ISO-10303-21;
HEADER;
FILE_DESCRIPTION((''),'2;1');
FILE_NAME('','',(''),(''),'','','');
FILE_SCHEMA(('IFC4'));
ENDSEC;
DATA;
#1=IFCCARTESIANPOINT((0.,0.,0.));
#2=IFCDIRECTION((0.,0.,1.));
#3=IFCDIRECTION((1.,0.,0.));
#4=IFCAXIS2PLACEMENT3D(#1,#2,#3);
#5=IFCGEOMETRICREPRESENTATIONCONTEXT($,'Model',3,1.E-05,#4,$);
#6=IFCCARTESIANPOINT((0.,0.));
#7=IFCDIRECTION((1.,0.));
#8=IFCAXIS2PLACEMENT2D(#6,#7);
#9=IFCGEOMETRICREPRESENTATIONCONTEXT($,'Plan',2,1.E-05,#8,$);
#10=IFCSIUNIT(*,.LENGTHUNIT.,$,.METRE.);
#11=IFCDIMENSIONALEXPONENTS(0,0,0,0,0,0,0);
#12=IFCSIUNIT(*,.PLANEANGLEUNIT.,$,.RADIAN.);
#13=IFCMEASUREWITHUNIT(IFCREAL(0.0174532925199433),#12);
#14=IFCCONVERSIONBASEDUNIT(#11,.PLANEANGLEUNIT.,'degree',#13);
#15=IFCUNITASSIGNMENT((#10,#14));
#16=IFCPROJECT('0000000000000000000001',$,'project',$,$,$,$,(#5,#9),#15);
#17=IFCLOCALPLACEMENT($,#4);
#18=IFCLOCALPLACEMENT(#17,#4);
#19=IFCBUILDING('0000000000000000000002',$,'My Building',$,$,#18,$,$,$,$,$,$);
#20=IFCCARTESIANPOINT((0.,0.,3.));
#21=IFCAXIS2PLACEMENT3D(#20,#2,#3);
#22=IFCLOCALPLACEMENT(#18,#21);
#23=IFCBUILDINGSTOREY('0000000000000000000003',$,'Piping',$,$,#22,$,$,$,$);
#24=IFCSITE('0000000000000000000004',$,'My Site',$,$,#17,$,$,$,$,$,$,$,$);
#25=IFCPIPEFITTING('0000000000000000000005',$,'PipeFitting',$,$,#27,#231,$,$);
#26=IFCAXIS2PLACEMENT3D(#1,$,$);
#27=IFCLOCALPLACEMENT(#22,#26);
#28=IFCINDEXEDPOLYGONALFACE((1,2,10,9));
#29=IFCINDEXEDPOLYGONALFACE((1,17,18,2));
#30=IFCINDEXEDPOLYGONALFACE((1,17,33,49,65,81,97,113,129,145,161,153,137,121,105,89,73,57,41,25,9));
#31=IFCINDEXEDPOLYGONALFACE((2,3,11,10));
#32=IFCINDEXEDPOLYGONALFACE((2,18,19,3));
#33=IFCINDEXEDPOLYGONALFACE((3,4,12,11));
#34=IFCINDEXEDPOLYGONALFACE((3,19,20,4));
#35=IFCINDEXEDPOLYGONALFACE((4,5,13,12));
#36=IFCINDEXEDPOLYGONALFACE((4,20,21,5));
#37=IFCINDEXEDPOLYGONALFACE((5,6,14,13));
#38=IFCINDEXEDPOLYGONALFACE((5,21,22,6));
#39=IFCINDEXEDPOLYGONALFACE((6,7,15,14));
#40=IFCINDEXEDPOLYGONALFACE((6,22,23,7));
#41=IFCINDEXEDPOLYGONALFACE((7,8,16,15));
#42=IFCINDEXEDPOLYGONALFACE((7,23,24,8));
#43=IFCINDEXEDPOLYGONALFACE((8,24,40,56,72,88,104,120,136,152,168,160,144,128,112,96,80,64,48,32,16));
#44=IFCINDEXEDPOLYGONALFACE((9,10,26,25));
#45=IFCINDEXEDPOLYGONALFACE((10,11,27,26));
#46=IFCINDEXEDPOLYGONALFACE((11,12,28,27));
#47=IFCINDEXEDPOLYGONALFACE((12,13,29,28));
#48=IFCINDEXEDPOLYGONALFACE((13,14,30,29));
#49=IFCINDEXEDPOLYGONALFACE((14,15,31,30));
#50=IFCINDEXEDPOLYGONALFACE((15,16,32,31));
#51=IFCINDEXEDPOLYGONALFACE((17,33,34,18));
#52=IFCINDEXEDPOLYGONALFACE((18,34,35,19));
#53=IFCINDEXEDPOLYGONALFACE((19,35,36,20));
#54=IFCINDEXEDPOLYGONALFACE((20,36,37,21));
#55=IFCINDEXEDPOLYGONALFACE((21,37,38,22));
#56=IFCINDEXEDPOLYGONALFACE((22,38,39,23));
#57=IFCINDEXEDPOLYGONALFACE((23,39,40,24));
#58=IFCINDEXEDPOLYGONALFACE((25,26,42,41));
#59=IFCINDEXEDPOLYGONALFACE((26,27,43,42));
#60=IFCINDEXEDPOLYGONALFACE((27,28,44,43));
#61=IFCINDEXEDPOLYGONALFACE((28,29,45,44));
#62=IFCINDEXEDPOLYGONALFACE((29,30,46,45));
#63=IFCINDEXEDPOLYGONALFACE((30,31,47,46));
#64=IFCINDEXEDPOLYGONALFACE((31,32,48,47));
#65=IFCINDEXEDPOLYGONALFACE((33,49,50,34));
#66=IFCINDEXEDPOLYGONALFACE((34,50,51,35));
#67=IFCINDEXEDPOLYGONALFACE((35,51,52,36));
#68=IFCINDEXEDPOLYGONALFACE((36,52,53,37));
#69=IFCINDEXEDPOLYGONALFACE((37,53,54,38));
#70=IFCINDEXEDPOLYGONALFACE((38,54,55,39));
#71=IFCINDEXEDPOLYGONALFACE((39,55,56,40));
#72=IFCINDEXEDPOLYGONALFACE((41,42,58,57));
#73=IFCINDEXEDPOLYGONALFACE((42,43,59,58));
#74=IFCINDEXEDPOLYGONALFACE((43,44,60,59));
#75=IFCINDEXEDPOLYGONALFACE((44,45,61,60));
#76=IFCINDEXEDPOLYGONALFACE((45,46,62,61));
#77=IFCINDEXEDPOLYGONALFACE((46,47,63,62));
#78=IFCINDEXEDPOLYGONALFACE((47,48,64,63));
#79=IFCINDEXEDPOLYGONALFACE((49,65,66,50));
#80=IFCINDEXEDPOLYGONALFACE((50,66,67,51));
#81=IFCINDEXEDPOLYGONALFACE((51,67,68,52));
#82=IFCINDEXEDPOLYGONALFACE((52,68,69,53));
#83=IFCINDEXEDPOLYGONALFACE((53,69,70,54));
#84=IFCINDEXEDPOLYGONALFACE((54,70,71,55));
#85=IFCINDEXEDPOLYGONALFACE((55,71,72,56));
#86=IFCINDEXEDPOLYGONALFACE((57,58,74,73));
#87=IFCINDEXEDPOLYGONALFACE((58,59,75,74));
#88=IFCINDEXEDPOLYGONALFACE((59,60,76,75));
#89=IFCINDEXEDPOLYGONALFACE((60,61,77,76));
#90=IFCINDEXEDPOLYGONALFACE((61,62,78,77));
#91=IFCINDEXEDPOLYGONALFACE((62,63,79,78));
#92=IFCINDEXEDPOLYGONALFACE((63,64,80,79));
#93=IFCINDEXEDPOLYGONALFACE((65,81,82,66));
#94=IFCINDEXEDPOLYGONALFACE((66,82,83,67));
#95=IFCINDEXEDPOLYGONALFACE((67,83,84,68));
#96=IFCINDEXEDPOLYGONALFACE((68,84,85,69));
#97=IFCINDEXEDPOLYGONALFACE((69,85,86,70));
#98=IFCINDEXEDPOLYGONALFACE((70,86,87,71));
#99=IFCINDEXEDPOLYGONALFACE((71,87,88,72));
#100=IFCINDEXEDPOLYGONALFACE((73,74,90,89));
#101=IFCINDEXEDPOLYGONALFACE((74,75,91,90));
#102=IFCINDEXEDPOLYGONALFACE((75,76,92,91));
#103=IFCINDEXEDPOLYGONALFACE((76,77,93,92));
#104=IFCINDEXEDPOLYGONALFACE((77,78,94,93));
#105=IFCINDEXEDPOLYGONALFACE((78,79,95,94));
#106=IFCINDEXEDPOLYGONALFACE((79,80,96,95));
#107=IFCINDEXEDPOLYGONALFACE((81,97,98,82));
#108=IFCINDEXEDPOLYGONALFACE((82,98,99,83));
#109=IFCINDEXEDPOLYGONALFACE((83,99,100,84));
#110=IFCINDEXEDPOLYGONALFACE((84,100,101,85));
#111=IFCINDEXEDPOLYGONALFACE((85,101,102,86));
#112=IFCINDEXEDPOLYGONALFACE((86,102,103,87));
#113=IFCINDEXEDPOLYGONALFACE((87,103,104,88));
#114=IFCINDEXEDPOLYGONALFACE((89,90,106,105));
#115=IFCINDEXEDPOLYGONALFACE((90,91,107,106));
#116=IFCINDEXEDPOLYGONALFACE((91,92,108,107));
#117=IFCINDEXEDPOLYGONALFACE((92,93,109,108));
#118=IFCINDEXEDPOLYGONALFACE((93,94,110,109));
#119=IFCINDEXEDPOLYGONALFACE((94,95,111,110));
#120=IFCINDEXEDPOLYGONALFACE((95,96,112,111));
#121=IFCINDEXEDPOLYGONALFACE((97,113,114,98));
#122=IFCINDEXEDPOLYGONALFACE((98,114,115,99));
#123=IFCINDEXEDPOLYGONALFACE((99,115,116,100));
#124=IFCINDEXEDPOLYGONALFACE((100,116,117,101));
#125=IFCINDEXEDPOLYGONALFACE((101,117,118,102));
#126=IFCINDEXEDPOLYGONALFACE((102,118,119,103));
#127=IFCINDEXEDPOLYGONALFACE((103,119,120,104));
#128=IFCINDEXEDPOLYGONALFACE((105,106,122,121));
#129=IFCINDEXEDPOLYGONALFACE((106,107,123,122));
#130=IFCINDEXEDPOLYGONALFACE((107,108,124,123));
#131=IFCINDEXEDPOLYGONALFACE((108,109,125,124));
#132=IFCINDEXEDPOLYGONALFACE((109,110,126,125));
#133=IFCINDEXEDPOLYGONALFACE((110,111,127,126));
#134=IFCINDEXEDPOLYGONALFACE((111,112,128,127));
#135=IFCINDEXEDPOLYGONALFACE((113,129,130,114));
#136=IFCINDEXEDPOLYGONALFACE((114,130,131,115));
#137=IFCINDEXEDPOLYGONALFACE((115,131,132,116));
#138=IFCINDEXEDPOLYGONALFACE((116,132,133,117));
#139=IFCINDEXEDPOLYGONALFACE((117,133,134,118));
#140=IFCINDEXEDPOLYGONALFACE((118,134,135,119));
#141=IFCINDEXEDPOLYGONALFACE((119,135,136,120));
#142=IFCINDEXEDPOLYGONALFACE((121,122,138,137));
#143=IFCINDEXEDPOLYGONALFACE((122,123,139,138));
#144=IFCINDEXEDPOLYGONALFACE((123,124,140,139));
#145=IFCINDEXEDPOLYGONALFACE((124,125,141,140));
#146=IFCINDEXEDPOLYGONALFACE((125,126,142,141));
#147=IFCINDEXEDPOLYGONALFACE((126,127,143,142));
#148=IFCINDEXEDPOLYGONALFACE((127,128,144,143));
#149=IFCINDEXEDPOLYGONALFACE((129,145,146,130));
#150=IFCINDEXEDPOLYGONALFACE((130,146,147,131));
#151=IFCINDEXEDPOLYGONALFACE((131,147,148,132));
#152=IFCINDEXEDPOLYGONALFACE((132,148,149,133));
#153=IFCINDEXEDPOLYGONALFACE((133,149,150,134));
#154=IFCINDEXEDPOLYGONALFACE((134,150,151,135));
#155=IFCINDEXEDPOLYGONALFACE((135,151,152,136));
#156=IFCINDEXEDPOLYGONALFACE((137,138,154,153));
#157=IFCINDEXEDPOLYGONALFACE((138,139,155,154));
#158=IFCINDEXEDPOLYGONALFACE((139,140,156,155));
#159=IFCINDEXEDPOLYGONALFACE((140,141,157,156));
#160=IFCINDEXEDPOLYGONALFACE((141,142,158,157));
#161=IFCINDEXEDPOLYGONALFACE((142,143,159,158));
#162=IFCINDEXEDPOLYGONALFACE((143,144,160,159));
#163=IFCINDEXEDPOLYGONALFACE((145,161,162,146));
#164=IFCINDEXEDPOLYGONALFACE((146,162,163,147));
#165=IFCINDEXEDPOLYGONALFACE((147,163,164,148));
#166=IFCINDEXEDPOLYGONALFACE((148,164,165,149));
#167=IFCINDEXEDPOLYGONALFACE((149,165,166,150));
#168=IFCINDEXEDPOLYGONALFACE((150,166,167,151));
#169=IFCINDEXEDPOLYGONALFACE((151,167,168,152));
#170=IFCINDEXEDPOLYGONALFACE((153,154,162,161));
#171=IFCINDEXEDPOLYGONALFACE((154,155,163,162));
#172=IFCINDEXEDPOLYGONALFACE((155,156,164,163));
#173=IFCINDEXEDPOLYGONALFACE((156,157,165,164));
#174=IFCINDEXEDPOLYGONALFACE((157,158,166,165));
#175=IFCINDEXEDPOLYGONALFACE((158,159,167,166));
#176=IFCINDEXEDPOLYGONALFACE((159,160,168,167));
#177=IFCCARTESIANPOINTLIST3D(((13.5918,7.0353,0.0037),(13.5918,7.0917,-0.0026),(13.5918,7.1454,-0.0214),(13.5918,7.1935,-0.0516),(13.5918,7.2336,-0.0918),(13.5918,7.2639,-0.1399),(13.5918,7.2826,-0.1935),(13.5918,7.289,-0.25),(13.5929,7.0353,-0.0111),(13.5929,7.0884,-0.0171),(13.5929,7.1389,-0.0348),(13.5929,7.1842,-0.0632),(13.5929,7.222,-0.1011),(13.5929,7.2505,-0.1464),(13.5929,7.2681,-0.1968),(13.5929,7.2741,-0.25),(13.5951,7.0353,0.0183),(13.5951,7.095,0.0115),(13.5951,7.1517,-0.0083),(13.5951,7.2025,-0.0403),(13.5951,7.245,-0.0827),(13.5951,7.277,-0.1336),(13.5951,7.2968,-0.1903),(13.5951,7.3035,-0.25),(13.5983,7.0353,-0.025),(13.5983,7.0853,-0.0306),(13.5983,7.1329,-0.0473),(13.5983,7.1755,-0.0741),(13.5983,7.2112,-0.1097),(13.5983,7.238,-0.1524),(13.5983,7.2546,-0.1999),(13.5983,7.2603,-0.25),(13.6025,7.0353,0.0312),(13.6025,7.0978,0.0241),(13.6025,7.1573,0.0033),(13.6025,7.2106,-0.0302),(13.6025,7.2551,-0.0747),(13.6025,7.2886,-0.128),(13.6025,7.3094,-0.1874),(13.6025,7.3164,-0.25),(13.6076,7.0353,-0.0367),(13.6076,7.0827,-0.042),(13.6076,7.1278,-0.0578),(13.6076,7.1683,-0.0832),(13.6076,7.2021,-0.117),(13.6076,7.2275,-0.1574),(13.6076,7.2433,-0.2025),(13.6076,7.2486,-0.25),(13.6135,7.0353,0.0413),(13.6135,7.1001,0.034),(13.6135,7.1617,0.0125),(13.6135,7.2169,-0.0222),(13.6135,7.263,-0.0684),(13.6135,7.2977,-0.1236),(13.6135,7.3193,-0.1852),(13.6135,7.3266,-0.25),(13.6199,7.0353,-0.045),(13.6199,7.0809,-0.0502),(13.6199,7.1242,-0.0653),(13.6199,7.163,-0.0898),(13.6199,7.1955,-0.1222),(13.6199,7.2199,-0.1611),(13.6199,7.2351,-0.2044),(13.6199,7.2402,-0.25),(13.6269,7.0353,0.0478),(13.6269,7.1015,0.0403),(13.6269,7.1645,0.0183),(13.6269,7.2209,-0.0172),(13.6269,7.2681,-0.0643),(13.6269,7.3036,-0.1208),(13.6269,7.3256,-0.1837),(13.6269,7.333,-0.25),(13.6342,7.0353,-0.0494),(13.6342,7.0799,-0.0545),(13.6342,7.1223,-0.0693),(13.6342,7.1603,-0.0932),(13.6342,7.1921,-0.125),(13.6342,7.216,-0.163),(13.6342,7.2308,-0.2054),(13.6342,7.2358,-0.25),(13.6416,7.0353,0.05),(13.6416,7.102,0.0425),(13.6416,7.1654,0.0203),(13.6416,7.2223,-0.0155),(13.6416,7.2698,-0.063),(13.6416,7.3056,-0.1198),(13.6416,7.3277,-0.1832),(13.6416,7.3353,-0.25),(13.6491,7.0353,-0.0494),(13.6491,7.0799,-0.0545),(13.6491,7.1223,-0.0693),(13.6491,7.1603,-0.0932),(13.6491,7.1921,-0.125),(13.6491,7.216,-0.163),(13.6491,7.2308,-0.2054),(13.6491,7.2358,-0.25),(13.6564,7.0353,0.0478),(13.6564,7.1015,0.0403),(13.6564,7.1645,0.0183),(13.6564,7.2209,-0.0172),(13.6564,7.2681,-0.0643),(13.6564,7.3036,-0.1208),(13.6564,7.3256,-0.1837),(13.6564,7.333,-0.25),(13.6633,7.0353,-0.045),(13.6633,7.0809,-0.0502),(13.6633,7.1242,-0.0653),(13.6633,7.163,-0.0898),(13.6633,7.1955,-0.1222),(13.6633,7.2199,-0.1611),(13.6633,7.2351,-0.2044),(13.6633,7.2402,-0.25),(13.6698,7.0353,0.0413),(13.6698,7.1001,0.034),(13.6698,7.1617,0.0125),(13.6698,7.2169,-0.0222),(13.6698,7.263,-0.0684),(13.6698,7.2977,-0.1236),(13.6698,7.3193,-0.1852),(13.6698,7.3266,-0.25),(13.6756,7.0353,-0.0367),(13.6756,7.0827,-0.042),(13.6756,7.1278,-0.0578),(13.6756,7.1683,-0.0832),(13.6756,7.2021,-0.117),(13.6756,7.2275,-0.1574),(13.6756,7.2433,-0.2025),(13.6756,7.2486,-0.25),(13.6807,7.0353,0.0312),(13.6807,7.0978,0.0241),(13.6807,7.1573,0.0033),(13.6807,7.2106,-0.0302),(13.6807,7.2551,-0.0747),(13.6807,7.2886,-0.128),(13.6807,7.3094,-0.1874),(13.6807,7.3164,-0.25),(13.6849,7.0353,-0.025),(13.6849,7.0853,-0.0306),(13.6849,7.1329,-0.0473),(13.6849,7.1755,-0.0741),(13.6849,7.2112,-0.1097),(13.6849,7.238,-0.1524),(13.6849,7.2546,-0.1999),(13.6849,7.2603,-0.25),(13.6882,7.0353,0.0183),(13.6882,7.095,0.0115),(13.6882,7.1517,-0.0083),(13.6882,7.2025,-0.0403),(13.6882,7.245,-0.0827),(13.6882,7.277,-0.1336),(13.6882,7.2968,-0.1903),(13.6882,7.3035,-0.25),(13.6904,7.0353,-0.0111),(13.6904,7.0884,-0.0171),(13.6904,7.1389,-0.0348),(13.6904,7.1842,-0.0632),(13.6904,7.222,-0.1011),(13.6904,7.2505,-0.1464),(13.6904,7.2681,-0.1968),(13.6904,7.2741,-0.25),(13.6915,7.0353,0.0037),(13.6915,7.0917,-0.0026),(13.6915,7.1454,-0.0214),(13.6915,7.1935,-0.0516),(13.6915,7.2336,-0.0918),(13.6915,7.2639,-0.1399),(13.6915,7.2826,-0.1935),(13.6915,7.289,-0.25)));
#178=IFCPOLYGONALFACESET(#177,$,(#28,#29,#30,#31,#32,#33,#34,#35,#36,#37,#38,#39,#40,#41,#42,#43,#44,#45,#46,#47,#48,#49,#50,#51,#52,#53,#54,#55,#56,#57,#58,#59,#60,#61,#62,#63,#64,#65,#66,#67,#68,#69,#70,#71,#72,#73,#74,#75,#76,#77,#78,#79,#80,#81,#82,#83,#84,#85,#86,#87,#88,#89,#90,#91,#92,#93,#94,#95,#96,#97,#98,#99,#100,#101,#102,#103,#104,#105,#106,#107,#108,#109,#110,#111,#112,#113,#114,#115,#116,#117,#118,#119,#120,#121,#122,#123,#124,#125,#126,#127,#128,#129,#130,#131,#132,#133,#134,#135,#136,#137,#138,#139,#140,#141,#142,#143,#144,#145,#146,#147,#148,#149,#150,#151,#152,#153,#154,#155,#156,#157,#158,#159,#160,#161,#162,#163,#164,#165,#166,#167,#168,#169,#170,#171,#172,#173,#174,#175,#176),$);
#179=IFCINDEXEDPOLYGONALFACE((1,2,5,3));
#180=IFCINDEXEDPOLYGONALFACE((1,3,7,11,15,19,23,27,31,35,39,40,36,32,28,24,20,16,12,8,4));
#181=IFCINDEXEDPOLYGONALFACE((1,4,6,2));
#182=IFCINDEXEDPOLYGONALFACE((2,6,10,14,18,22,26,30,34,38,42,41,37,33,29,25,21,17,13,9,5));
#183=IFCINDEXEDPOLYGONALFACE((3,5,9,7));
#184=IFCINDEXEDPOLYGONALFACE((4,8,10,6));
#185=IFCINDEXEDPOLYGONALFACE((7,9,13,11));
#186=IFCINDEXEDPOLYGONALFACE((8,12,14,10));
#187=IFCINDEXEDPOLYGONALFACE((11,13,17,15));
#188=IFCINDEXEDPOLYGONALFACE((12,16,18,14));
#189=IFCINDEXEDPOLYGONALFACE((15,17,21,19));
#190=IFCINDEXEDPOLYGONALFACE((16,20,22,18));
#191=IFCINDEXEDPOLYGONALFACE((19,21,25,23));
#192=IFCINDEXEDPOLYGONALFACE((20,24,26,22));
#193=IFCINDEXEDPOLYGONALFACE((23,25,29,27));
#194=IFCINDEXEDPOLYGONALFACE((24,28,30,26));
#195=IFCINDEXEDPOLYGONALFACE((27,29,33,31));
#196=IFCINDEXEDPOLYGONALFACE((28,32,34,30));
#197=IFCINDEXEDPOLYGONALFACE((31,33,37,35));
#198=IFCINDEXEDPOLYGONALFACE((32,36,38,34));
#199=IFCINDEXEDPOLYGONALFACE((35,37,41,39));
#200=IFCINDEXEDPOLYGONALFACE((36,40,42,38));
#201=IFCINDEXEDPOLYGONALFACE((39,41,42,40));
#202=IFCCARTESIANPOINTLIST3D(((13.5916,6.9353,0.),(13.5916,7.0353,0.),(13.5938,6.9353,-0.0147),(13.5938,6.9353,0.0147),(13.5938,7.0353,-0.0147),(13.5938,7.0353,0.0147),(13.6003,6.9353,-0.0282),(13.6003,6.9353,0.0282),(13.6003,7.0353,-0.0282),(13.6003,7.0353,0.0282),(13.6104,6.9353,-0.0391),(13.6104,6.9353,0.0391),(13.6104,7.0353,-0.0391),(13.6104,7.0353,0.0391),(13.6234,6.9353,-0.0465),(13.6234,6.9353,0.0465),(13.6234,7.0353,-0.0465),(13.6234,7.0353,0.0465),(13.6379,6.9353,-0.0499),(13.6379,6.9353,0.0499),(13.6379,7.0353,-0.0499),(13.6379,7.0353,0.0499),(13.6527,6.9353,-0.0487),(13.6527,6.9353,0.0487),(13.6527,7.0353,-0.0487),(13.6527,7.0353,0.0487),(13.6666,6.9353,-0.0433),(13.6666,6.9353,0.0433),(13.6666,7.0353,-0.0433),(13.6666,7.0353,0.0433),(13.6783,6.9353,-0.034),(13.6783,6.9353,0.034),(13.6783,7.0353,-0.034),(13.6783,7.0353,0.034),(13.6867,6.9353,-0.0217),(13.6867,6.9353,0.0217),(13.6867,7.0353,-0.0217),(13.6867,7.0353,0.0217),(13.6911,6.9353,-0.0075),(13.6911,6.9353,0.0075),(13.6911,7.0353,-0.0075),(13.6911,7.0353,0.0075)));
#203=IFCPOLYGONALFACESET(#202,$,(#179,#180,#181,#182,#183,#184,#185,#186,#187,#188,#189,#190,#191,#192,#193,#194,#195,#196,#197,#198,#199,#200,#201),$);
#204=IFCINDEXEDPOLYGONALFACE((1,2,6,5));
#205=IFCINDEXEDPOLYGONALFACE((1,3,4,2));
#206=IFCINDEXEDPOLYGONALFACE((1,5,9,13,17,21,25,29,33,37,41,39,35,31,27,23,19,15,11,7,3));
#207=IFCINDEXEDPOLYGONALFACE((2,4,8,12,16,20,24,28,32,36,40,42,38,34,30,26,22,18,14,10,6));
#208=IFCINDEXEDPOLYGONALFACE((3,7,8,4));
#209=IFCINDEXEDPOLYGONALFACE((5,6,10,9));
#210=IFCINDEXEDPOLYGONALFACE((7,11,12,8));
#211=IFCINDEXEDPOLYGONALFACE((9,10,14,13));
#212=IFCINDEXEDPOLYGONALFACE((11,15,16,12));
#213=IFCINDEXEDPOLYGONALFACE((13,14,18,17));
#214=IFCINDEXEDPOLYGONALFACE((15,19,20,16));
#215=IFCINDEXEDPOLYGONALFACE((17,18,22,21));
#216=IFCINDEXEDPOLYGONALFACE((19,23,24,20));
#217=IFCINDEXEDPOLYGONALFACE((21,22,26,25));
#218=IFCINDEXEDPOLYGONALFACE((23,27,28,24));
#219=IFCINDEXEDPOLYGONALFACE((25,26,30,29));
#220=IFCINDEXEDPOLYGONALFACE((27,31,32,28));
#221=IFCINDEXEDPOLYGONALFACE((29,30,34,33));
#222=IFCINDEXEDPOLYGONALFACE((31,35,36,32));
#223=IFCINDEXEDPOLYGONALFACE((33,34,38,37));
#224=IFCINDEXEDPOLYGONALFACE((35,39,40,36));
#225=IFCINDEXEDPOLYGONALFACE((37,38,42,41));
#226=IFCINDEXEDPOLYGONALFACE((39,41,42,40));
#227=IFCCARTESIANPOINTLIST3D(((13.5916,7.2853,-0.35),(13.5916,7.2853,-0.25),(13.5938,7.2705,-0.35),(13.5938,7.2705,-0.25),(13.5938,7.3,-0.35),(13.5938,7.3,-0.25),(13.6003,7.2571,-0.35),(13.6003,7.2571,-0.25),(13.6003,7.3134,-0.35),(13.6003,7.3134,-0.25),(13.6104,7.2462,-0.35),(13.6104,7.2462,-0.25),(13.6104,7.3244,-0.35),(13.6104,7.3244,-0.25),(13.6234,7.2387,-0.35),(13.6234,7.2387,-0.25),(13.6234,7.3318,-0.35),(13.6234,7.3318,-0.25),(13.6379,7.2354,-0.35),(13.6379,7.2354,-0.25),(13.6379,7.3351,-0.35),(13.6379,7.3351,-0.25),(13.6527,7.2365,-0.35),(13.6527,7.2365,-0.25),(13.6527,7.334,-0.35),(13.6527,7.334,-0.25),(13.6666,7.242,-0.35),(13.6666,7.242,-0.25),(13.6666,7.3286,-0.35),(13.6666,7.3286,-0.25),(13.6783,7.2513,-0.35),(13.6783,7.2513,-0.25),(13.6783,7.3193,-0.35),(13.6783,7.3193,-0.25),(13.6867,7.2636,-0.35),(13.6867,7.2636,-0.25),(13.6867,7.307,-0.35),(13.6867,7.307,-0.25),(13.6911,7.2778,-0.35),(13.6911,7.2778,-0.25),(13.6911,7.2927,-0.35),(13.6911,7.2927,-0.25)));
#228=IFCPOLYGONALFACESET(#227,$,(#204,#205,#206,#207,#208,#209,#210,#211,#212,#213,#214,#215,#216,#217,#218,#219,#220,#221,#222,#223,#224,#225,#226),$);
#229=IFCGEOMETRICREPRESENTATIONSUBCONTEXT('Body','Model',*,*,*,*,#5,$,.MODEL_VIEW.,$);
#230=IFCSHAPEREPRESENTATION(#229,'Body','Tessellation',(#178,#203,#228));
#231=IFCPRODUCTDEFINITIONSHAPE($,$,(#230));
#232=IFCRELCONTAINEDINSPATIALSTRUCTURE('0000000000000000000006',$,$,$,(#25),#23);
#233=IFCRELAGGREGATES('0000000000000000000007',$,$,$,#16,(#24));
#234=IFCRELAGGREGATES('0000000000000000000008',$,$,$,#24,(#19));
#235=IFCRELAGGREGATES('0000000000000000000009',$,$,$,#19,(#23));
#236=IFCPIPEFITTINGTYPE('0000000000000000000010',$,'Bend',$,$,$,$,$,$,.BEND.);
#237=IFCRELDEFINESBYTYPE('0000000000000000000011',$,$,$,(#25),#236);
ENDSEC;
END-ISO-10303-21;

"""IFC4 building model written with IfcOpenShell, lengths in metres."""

from ifc_helpers import new_model, entity, si_unit, converted_unit, frame, origin_with_axes, origin_2d_with_axis, place, context, subcontext, project, spatial, circle, extrude, source, transform, mapped, type_object, type_shapes, element, save


model = new_model("IFC4")

# Units and contexts
model_context = context("Model", 3, precision=1e-05, world=origin_with_axes())
plan_context = context("Plan", 2, precision=1e-05, world=origin_2d_with_axis())
body_context = subcontext(model_context, "Body", "Model", "MODEL_VIEW")
ifc_project = project(units=[si_unit("LENGTHUNIT", "METRE"), converted_unit("PLANEANGLEUNIT", "degree", entity("IfcReal", 0.0174532925199433), si_unit("PLANEANGLEUNIT", "RADIAN"), dimensions=[0, 0, 0, 0, 0, 0, 0])], contexts=[model_context, plan_context])

# Site, building, storey
site_placement = place(None, origin_with_axes())
site = spatial("IfcSite", under=ifc_project, at=site_placement, Name="My Site")
building_placement = place(site_placement, origin_with_axes())
building = spatial("IfcBuilding", under=site, at=building_placement, Name="My Building")
storey_placement = place(building_placement, frame((0.0, 0.0, 3.0), z_axis=(0.0, 0.0, 1.0), x_axis=(1.0, 0.0, 0.0)))
storey = spatial("IfcBuildingStorey", under=building, at=storey_placement, Name="Piping")

# Pipe fitting
pipe_fitting_type_1 = type_object("IfcPipeFittingType", Name="Bend", PredefinedType="BEND")
shared_shape = source(origin_with_axes(), body_context, "Body", "SolidModel", [
    entity("IfcSweptDiskSolid", entity("IfcIndexedPolyCurve", entity("IfcCartesianPointList3D", [[0.0, 0.0, -0.1], [0.0, 0.0732, -0.2768], [0.0, 0.25, -0.35]]), [entity("IfcArcIndex", [1, 2, 3])]), 0.05),
    extrude(circle(Radius=0.05), origin_with_axes(), (0.0, 0.0, -1.0), 0.1),
    extrude(circle(Radius=0.05), frame((0.0, 0.25, -0.35), z_axis=(0.0, 1.0, 0.0), x_axis=(1.0, 0.0, 0.0)), (0.0, 0.0, 1.0), 0.1),
])
type_shapes(pipe_fitting_type_1, [shared_shape])
for number, where, z_axis, x_axis, name in (
    (1, (13.6416, 6.9353, 0.0), (0.0, -1.0, 0.0), (-1.0, 0.0, 0.0), "PipeFitting"),
):
    element("IfcPipeFitting", number, at=place(storey_placement, frame(where, z_axis=z_axis, x_axis=x_axis)), inside=storey, type_object=pipe_fitting_type_1, Name=name, context=body_context, shape_type="MappedRepresentation", body=[
        mapped(shared_shape, transform((0.0, 0.0, 0.0), x_axis=(1.0, 0.0, 0.0), y_axis=(0.0, 1.0, 0.0), z_axis=(0.0, 0.0, 1.0), scale=1.0)),
    ])

save(model, "model.ifc")
